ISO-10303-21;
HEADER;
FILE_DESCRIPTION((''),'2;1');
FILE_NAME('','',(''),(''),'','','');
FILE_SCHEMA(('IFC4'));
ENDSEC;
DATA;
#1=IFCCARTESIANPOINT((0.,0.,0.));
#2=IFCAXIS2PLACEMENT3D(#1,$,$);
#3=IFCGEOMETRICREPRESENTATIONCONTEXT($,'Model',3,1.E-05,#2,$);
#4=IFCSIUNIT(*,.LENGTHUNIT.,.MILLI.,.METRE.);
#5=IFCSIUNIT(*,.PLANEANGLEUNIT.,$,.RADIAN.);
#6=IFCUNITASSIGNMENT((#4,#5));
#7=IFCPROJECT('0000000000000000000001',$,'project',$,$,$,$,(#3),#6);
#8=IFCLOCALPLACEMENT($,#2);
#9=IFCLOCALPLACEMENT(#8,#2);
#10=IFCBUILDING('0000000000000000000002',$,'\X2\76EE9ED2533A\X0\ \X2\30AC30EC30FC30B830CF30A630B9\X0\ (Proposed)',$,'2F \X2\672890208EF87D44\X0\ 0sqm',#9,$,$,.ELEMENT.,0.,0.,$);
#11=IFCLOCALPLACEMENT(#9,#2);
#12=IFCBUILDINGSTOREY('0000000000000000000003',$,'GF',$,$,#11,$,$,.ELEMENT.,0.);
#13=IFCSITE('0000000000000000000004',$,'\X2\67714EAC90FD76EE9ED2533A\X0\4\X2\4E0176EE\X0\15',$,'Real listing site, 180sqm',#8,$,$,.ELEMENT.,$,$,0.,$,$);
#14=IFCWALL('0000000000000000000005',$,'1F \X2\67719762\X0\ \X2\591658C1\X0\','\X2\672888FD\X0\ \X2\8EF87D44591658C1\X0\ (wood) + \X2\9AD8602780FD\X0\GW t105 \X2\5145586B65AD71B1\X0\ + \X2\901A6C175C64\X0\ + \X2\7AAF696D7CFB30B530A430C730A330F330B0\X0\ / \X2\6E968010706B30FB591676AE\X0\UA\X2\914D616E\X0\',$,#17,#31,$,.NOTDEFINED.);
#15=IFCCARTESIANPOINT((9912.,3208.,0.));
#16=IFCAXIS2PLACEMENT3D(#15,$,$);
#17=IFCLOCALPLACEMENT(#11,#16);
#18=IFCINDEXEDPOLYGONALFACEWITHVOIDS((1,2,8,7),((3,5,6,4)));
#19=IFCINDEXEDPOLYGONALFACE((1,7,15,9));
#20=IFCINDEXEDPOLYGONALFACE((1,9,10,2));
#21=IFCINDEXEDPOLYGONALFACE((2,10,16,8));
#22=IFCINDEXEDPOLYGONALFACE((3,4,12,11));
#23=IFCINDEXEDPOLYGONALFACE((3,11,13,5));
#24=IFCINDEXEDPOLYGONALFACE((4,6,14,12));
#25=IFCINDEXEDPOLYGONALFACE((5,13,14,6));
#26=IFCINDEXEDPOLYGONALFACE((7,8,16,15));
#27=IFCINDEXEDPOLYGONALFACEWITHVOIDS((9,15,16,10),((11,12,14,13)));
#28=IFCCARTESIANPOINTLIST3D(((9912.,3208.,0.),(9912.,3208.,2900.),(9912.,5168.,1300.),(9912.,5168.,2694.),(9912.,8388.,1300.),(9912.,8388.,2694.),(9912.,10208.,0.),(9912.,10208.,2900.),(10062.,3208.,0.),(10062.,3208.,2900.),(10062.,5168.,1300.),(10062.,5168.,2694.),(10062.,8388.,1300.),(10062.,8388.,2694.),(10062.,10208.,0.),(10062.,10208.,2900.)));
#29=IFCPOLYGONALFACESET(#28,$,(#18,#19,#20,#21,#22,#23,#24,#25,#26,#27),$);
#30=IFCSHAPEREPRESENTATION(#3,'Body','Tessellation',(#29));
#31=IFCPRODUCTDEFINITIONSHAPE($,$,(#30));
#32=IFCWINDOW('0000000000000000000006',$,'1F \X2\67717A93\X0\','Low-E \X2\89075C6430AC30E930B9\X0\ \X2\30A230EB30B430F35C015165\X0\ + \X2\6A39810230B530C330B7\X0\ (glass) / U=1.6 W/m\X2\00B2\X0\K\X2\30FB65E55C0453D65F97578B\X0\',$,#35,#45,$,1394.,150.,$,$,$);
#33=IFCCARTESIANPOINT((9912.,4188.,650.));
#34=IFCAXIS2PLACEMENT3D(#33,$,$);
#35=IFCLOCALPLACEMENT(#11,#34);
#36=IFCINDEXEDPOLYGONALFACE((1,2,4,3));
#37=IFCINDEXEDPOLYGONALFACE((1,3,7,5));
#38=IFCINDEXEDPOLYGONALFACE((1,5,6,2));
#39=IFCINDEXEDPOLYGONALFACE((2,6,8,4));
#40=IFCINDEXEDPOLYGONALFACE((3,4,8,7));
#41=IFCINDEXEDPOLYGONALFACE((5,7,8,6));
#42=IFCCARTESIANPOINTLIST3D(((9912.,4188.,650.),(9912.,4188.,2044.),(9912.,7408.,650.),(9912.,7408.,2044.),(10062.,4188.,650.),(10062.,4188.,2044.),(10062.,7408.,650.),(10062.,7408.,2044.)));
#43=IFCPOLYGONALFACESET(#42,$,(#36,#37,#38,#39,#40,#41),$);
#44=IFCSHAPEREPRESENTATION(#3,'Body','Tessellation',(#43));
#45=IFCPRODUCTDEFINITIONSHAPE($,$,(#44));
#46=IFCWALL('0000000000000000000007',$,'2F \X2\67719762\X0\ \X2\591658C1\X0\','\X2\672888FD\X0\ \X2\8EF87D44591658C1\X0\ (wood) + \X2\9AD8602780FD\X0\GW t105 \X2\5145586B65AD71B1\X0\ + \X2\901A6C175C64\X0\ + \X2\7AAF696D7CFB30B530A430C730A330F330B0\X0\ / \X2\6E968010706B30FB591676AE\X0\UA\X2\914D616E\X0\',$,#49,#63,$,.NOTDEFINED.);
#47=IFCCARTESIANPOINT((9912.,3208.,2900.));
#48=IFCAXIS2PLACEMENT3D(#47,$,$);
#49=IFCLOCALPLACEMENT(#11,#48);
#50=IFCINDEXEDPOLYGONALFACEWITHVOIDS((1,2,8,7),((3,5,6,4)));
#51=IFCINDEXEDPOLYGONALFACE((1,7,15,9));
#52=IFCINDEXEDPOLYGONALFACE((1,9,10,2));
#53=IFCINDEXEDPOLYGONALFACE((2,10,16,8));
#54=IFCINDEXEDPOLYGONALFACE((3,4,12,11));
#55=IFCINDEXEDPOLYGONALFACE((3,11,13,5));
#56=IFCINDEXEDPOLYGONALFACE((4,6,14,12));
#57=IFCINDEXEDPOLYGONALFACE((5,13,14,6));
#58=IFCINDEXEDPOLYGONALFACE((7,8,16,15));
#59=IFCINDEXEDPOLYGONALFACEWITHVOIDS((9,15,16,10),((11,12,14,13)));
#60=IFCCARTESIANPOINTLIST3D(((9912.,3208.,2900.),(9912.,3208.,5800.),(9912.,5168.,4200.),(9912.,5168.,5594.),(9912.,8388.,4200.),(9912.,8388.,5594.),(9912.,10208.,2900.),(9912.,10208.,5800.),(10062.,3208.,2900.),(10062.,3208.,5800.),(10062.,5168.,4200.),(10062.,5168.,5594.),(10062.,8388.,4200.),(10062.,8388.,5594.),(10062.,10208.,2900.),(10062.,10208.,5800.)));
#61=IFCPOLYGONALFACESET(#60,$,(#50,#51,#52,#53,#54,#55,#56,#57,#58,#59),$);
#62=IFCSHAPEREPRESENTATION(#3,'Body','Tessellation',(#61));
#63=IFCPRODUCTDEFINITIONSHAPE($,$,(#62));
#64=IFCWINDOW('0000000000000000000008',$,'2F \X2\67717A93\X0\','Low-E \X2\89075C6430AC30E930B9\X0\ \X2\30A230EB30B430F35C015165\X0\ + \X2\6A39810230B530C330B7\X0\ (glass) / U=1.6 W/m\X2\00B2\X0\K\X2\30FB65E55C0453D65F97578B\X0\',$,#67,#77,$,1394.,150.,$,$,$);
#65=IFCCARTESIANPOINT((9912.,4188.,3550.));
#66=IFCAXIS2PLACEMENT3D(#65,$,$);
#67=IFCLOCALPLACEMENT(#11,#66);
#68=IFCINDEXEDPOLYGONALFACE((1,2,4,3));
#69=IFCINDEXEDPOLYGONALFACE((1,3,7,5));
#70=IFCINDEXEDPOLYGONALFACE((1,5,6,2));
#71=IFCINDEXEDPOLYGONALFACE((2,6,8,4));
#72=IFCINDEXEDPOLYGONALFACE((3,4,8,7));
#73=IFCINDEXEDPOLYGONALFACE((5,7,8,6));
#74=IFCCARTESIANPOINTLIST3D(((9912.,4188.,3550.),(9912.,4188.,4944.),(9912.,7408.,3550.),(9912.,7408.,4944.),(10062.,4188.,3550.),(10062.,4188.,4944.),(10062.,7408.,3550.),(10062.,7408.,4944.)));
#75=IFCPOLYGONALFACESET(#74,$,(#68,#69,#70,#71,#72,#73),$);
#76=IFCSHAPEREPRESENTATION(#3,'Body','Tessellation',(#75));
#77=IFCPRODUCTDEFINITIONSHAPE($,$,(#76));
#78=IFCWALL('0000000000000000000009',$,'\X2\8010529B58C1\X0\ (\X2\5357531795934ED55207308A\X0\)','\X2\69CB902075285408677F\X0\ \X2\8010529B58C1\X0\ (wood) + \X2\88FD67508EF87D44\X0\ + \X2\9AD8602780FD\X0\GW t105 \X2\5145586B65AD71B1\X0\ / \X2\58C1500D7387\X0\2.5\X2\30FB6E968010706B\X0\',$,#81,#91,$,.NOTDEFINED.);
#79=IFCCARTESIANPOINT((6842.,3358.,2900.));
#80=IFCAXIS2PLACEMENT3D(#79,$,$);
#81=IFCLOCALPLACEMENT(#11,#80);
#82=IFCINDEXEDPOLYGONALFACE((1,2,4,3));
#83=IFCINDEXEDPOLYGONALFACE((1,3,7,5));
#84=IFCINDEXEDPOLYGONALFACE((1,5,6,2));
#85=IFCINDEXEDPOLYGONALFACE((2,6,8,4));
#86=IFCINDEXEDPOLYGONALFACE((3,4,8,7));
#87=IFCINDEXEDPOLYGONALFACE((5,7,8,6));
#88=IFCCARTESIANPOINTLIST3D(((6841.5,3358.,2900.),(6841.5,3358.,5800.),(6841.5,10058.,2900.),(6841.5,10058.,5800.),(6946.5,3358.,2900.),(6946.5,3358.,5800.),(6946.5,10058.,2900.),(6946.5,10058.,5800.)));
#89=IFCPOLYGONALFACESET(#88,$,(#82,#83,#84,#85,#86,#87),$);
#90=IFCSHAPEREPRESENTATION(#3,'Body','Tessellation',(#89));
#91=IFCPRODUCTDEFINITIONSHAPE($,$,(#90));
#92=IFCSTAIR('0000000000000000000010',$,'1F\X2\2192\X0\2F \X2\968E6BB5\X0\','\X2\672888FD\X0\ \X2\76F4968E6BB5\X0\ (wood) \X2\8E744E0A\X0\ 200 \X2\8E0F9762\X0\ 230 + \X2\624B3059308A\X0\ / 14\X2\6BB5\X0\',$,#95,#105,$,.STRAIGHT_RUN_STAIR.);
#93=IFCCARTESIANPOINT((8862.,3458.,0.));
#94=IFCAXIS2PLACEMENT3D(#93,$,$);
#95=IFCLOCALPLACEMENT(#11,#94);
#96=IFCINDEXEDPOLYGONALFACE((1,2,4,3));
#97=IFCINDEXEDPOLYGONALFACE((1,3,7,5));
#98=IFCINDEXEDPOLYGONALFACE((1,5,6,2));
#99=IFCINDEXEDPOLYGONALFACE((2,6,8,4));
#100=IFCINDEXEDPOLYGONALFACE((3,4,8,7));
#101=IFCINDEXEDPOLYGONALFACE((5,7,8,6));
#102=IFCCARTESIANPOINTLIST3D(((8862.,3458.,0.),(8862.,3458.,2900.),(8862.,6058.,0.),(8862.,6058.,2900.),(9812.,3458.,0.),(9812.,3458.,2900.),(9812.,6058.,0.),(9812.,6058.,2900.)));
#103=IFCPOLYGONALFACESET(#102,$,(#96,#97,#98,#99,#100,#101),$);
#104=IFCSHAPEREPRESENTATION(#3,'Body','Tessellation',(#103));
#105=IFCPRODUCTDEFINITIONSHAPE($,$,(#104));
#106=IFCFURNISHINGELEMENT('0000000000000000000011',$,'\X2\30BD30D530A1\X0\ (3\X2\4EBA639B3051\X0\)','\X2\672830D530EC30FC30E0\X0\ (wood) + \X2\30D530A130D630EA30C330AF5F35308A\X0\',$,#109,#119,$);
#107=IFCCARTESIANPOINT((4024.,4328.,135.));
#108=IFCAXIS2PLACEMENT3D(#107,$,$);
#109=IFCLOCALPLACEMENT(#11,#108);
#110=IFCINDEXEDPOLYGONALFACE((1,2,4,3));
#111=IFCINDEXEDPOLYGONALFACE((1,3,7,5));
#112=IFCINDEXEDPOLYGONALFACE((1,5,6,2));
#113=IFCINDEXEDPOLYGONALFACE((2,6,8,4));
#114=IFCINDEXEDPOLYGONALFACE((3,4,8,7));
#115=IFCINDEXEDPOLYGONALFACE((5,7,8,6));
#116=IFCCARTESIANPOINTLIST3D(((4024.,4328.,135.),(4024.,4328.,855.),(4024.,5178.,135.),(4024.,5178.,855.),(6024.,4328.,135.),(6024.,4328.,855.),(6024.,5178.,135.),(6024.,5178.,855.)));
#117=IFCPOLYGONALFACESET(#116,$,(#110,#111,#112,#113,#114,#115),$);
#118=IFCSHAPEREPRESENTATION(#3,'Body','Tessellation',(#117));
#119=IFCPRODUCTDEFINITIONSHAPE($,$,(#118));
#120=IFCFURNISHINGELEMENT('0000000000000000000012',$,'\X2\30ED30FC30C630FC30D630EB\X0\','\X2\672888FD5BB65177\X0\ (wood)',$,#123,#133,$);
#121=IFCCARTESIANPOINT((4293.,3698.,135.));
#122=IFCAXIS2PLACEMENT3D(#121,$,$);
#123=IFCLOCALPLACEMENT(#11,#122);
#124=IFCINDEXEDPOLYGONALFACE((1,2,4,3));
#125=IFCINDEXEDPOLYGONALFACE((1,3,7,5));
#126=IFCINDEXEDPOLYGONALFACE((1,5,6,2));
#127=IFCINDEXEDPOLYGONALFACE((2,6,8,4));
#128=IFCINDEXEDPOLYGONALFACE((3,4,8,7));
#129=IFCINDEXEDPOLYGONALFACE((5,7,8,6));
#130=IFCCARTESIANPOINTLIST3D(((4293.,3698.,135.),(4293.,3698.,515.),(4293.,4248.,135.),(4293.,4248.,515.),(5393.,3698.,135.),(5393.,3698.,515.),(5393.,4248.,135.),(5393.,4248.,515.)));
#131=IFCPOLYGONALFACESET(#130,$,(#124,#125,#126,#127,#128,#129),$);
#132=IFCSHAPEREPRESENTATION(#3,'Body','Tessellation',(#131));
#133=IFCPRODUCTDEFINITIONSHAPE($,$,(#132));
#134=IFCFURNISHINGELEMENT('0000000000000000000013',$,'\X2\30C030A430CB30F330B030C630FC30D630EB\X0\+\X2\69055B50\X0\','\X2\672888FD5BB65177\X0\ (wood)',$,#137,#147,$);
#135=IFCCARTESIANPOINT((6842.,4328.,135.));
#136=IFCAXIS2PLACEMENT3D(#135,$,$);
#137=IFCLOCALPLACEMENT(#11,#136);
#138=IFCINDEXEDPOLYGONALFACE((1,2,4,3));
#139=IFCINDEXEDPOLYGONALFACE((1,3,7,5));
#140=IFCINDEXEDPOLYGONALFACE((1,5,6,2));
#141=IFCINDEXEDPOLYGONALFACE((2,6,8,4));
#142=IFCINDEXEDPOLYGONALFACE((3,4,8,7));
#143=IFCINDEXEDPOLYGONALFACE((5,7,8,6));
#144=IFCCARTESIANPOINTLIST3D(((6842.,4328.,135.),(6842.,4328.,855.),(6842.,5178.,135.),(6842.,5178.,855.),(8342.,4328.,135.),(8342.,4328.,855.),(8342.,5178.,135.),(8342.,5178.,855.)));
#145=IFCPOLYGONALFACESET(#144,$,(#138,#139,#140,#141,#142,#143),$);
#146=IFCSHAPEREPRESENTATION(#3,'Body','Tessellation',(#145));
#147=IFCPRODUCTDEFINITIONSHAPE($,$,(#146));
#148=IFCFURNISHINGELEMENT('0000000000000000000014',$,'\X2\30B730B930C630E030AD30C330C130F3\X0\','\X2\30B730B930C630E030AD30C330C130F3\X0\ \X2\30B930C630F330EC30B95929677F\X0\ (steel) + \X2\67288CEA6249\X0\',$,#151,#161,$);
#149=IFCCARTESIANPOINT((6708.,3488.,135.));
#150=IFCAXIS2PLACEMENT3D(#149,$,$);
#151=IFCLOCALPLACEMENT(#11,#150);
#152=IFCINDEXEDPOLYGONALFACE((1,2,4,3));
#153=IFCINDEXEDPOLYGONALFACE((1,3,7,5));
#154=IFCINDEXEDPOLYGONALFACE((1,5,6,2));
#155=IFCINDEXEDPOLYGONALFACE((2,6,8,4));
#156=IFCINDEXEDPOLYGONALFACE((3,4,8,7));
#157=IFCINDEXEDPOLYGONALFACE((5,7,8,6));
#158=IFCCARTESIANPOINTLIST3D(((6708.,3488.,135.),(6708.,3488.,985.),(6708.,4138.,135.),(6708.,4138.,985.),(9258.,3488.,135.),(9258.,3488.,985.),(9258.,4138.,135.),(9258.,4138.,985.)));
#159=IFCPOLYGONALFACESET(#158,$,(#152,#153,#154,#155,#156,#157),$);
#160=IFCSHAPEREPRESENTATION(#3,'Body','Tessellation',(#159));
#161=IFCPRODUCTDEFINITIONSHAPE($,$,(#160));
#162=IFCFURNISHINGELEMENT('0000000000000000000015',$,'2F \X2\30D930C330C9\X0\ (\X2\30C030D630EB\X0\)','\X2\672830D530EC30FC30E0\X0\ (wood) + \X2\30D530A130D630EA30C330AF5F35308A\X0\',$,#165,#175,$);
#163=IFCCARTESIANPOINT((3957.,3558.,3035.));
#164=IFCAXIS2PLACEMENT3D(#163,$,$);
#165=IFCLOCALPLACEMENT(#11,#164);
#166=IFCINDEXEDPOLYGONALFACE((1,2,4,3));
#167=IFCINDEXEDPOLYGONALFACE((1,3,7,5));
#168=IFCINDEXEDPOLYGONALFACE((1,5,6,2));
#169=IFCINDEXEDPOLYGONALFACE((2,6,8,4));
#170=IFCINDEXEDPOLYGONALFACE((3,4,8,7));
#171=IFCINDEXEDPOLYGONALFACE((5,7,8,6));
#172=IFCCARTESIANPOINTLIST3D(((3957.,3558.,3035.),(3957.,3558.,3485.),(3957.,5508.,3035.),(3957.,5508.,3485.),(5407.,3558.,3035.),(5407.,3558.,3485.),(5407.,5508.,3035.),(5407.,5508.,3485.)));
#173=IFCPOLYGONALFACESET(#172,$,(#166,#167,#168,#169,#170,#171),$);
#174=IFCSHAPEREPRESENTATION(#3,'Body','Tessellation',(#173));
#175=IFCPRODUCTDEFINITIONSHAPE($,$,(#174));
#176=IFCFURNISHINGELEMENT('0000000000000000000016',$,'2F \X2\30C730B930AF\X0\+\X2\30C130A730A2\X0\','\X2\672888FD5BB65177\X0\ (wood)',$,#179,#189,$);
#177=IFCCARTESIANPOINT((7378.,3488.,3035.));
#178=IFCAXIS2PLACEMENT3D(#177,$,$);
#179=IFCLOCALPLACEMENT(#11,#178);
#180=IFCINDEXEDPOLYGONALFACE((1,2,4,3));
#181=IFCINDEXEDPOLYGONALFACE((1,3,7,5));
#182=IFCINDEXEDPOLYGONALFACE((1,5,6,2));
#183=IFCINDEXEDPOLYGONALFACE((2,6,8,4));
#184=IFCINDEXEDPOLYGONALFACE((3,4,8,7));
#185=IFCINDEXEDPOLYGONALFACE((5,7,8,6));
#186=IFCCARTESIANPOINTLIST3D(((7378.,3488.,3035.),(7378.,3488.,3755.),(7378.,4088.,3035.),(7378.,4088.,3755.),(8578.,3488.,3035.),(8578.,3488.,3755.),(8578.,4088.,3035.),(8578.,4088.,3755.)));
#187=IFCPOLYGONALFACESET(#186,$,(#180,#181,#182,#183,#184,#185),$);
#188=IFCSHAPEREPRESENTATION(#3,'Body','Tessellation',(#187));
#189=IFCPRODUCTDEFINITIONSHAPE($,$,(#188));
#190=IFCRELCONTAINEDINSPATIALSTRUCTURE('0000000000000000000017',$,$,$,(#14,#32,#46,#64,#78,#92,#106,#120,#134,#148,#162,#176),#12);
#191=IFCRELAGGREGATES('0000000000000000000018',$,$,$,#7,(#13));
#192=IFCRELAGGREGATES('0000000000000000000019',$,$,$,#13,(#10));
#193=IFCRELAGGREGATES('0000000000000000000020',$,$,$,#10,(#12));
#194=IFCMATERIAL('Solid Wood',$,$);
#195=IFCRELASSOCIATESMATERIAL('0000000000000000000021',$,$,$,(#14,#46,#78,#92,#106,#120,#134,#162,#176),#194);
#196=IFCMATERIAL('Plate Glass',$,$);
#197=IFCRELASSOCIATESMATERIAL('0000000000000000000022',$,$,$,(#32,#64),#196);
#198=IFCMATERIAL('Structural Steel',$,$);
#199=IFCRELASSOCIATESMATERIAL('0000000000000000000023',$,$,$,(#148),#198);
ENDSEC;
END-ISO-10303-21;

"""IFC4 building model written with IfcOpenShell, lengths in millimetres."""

from ifc_helpers import new_model, si_unit, frame, frame_2d, origin, place, context, project, spatial, rectangle, extrude, material, element, fill, save


model = new_model("IFC4")

# Units and contexts
model_context = context("Model", 3, precision=1e-05, world=origin())
ifc_project = project(units=[si_unit("LENGTHUNIT", "METRE", prefix="MILLI"), si_unit("PLANEANGLEUNIT", "RADIAN")], contexts=[model_context])

# Site, building, storey
site_placement = place(None, origin())
site = spatial("IfcSite", under=ifc_project, at=site_placement, Name="東京都目黒区4丁目15", ObjectType="Real listing site, 180sqm", CompositionType="ELEMENT", RefElevation=0.0)
building_placement = place(site_placement, origin())
building = spatial("IfcBuilding", under=site, at=building_placement, Name="目黒区 ガレージハウス (Proposed)", ObjectType="2F 木造軸組 0sqm", CompositionType="ELEMENT", ElevationOfRefHeight=0.0, ElevationOfTerrain=0.0)
storey_placement = place(building_placement, origin())
storey = spatial("IfcBuildingStorey", under=building, at=storey_placement, Name="GF", CompositionType="ELEMENT", Elevation=0.0)

# Wall, opening, window
ifc_material_1 = material(Name="Solid Wood")
wall_1_placement = place(storey_placement, frame((9912.0, 3208.0, 0.0)))
wall_1 = element("IfcWall", 1, at=wall_1_placement, inside=storey, material=ifc_material_1, Name="1F 東面 外壁", Description="木製 軸組外壁 (wood) + 高性能GW t105 充填断熱 + 通気層 + 窯業系サイディング / 準耐火・外皮UA配慮", PredefinedType="NOTDEFINED", context=model_context, shape_type="SweptSolid", body=[
    extrude(rectangle(XDim=150.0, YDim=7000.0, at=frame_2d((75.0, 3500.0))), frame((9912.0, 3208.0, 0.0)), (0.0, 0.0, 1.0), 2900.0),
])
opening_1_placement = place(storey_placement, frame((9912.0, 4188.0, 650.0)))
opening_1 = element("IfcOpeningElement", 2, at=opening_1_placement, cuts=wall_1, PredefinedType="NOTDEFINED", context=model_context, shape_type="SweptSolid", body=[
    extrude(rectangle(XDim=150.0, YDim=3220.0, at=frame_2d((75.0, 1610.0))), frame((9912.0, 4188.0, 650.0)), (0.0, 0.0, 1.0), 1394.0),
])
ifc_material_2 = material(Name="Plate Glass")
window_1_placement = place(storey_placement, frame((9912.0, 4188.0, 650.0)))
window_1 = element("IfcWindow", 3, at=window_1_placement, inside=storey, material=ifc_material_2, Name="1F 東窓", Description="Low-E 複層ガラス アルゴン封入 + 樹脂サッシ (glass) / U=1.6 W/m²K・日射取得型", OverallHeight=1394.0, OverallWidth=150.0, context=model_context, shape_type="SweptSolid", body=[
    extrude(rectangle(XDim=150.0, YDim=3220.0, at=frame_2d((75.0, 1610.0))), frame((9912.0, 4188.0, 650.0)), (0.0, 0.0, 1.0), 1394.0),
])
fill(opening_1, window_1)

# Wall, opening, window
wall_2_placement = place(storey_placement, frame((9912.0, 3208.0, 2900.0)))
wall_2 = element("IfcWall", 4, at=wall_2_placement, inside=storey, material=ifc_material_1, Name="2F 東面 外壁", Description="木製 軸組外壁 (wood) + 高性能GW t105 充填断熱 + 通気層 + 窯業系サイディング / 準耐火・外皮UA配慮", PredefinedType="NOTDEFINED", context=model_context, shape_type="SweptSolid", body=[
    extrude(rectangle(XDim=150.0, YDim=7000.0, at=frame_2d((75.0, 3500.0))), frame((9912.0, 3208.0, 2900.0)), (0.0, 0.0, 1.0), 2900.0),
])
opening_2_placement = place(storey_placement, frame((9912.0, 4188.0, 3550.0)))
opening_2 = element("IfcOpeningElement", 5, at=opening_2_placement, cuts=wall_2, PredefinedType="NOTDEFINED", context=model_context, shape_type="SweptSolid", body=[
    extrude(rectangle(XDim=150.0, YDim=3220.0, at=frame_2d((75.0, 1610.0))), frame((9912.0, 4188.0, 3550.0)), (0.0, 0.0, 1.0), 1394.0),
])
window_2_placement = place(storey_placement, frame((9912.0, 4188.0, 3550.0)))
window_2 = element("IfcWindow", 6, at=window_2_placement, inside=storey, material=ifc_material_2, Name="2F 東窓", Description="Low-E 複層ガラス アルゴン封入 + 樹脂サッシ (glass) / U=1.6 W/m²K・日射取得型", OverallHeight=1394.0, OverallWidth=150.0, context=model_context, shape_type="SweptSolid", body=[
    extrude(rectangle(XDim=150.0, YDim=3220.0, at=frame_2d((75.0, 1610.0))), frame((9912.0, 4188.0, 3550.0)), (0.0, 0.0, 1.0), 1394.0),
])
fill(opening_2, window_2)

# Wall
wall_3_placement = place(storey_placement, frame((6842.0, 3358.0, 2900.0)))
element("IfcWall", 7, at=wall_3_placement, inside=storey, material=ifc_material_1, Name="耐力壁 (南北間仕切り)", Description="構造用合板 耐力壁 (wood) + 製材軸組 + 高性能GW t105 充填断熱 / 壁倍率2.5・準耐火", PredefinedType="NOTDEFINED", context=model_context, shape_type="SweptSolid", body=[
    extrude(rectangle(XDim=105.0, YDim=6700.0, at=frame_2d((52.0, 3350.0))), frame((6842.0, 3358.0, 2900.0)), (0.0, 0.0, 1.0), 2900.0),
])

# Stair
stair_placement = place(storey_placement, frame((8862.0, 3458.0, 0.0)))
element("IfcStair", 8, at=stair_placement, inside=storey, material=ifc_material_1, Name="1F→2F 階段", Description="木製 直階段 (wood) 蹴上 200 踏面 230 + 手すり / 14段", PredefinedType="STRAIGHT_RUN_STAIR", context=model_context, shape_type="SweptSolid", body=[
    extrude(rectangle(XDim=950.0, YDim=2600.0, at=frame_2d((475.0, 1300.0))), frame((8862.0, 3458.0, 0.0)), (0.0, 0.0, 1.0), 2900.0),
])

# Furnishing elements
furnishing_1_placement = place(storey_placement, frame((4024.0, 4328.0, 135.0)))
element("IfcFurnishingElement", 9, at=furnishing_1_placement, inside=storey, material=ifc_material_1, Name="ソファ (3人掛け)", Description="木フレーム (wood) + ファブリック張り", context=model_context, shape_type="SweptSolid", body=[
    extrude(rectangle(XDim=2000.0, YDim=850.0, at=frame_2d((1000.0, 425.0))), frame((4024.0, 4328.0, 135.0)), (0.0, 0.0, 1.0), 720.0),
])
furnishing_2_placement = place(storey_placement, frame((4293.0, 3698.0, 135.0)))
element("IfcFurnishingElement", 10, at=furnishing_2_placement, inside=storey, material=ifc_material_1, Name="ローテーブル", Description="木製家具 (wood)", context=model_context, shape_type="SweptSolid", body=[
    extrude(rectangle(XDim=1100.0, YDim=550.0, at=frame_2d((550.0, 275.0))), frame((4293.0, 3698.0, 135.0)), (0.0, 0.0, 1.0), 380.0),
])
furnishing_3_placement = place(storey_placement, frame((6842.0, 4328.0, 135.0)))
element("IfcFurnishingElement", 11, at=furnishing_3_placement, inside=storey, material=ifc_material_1, Name="ダイニングテーブル+椅子", Description="木製家具 (wood)", context=model_context, shape_type="SweptSolid", body=[
    extrude(rectangle(XDim=1500.0, YDim=850.0, at=frame_2d((750.0, 425.0))), frame((6842.0, 4328.0, 135.0)), (0.0, 0.0, 1.0), 720.0),
])
ifc_material_3 = material(Name="Structural Steel")
furnishing_4_placement = place(storey_placement, frame((6708.0, 3488.0, 135.0)))
element("IfcFurnishingElement", 12, at=furnishing_4_placement, inside=storey, material=ifc_material_3, Name="システムキッチン", Description="システムキッチン ステンレス天板 (steel) + 木質扉", context=model_context, shape_type="SweptSolid", body=[
    extrude(rectangle(XDim=2550.0, YDim=650.0, at=frame_2d((1275.0, 325.0))), frame((6708.0, 3488.0, 135.0)), (0.0, 0.0, 1.0), 850.0),
])
furnishing_5_placement = place(storey_placement, frame((3957.0, 3558.0, 3035.0)))
element("IfcFurnishingElement", 13, at=furnishing_5_placement, inside=storey, material=ifc_material_1, Name="2F ベッド (ダブル)", Description="木フレーム (wood) + ファブリック張り", context=model_context, shape_type="SweptSolid", body=[
    extrude(rectangle(XDim=1450.0, YDim=1950.0, at=frame_2d((725.0, 975.0))), frame((3957.0, 3558.0, 3035.0)), (0.0, 0.0, 1.0), 450.0),
])
furnishing_6_placement = place(storey_placement, frame((7378.0, 3488.0, 3035.0)))
element("IfcFurnishingElement", 14, at=furnishing_6_placement, inside=storey, material=ifc_material_1, Name="2F デスク+チェア", Description="木製家具 (wood)", context=model_context, shape_type="SweptSolid", body=[
    extrude(rectangle(XDim=1200.0, YDim=600.0, at=frame_2d((600.0, 300.0))), frame((7378.0, 3488.0, 3035.0)), (0.0, 0.0, 1.0), 720.0),
])

save(model, "model.ifc")
